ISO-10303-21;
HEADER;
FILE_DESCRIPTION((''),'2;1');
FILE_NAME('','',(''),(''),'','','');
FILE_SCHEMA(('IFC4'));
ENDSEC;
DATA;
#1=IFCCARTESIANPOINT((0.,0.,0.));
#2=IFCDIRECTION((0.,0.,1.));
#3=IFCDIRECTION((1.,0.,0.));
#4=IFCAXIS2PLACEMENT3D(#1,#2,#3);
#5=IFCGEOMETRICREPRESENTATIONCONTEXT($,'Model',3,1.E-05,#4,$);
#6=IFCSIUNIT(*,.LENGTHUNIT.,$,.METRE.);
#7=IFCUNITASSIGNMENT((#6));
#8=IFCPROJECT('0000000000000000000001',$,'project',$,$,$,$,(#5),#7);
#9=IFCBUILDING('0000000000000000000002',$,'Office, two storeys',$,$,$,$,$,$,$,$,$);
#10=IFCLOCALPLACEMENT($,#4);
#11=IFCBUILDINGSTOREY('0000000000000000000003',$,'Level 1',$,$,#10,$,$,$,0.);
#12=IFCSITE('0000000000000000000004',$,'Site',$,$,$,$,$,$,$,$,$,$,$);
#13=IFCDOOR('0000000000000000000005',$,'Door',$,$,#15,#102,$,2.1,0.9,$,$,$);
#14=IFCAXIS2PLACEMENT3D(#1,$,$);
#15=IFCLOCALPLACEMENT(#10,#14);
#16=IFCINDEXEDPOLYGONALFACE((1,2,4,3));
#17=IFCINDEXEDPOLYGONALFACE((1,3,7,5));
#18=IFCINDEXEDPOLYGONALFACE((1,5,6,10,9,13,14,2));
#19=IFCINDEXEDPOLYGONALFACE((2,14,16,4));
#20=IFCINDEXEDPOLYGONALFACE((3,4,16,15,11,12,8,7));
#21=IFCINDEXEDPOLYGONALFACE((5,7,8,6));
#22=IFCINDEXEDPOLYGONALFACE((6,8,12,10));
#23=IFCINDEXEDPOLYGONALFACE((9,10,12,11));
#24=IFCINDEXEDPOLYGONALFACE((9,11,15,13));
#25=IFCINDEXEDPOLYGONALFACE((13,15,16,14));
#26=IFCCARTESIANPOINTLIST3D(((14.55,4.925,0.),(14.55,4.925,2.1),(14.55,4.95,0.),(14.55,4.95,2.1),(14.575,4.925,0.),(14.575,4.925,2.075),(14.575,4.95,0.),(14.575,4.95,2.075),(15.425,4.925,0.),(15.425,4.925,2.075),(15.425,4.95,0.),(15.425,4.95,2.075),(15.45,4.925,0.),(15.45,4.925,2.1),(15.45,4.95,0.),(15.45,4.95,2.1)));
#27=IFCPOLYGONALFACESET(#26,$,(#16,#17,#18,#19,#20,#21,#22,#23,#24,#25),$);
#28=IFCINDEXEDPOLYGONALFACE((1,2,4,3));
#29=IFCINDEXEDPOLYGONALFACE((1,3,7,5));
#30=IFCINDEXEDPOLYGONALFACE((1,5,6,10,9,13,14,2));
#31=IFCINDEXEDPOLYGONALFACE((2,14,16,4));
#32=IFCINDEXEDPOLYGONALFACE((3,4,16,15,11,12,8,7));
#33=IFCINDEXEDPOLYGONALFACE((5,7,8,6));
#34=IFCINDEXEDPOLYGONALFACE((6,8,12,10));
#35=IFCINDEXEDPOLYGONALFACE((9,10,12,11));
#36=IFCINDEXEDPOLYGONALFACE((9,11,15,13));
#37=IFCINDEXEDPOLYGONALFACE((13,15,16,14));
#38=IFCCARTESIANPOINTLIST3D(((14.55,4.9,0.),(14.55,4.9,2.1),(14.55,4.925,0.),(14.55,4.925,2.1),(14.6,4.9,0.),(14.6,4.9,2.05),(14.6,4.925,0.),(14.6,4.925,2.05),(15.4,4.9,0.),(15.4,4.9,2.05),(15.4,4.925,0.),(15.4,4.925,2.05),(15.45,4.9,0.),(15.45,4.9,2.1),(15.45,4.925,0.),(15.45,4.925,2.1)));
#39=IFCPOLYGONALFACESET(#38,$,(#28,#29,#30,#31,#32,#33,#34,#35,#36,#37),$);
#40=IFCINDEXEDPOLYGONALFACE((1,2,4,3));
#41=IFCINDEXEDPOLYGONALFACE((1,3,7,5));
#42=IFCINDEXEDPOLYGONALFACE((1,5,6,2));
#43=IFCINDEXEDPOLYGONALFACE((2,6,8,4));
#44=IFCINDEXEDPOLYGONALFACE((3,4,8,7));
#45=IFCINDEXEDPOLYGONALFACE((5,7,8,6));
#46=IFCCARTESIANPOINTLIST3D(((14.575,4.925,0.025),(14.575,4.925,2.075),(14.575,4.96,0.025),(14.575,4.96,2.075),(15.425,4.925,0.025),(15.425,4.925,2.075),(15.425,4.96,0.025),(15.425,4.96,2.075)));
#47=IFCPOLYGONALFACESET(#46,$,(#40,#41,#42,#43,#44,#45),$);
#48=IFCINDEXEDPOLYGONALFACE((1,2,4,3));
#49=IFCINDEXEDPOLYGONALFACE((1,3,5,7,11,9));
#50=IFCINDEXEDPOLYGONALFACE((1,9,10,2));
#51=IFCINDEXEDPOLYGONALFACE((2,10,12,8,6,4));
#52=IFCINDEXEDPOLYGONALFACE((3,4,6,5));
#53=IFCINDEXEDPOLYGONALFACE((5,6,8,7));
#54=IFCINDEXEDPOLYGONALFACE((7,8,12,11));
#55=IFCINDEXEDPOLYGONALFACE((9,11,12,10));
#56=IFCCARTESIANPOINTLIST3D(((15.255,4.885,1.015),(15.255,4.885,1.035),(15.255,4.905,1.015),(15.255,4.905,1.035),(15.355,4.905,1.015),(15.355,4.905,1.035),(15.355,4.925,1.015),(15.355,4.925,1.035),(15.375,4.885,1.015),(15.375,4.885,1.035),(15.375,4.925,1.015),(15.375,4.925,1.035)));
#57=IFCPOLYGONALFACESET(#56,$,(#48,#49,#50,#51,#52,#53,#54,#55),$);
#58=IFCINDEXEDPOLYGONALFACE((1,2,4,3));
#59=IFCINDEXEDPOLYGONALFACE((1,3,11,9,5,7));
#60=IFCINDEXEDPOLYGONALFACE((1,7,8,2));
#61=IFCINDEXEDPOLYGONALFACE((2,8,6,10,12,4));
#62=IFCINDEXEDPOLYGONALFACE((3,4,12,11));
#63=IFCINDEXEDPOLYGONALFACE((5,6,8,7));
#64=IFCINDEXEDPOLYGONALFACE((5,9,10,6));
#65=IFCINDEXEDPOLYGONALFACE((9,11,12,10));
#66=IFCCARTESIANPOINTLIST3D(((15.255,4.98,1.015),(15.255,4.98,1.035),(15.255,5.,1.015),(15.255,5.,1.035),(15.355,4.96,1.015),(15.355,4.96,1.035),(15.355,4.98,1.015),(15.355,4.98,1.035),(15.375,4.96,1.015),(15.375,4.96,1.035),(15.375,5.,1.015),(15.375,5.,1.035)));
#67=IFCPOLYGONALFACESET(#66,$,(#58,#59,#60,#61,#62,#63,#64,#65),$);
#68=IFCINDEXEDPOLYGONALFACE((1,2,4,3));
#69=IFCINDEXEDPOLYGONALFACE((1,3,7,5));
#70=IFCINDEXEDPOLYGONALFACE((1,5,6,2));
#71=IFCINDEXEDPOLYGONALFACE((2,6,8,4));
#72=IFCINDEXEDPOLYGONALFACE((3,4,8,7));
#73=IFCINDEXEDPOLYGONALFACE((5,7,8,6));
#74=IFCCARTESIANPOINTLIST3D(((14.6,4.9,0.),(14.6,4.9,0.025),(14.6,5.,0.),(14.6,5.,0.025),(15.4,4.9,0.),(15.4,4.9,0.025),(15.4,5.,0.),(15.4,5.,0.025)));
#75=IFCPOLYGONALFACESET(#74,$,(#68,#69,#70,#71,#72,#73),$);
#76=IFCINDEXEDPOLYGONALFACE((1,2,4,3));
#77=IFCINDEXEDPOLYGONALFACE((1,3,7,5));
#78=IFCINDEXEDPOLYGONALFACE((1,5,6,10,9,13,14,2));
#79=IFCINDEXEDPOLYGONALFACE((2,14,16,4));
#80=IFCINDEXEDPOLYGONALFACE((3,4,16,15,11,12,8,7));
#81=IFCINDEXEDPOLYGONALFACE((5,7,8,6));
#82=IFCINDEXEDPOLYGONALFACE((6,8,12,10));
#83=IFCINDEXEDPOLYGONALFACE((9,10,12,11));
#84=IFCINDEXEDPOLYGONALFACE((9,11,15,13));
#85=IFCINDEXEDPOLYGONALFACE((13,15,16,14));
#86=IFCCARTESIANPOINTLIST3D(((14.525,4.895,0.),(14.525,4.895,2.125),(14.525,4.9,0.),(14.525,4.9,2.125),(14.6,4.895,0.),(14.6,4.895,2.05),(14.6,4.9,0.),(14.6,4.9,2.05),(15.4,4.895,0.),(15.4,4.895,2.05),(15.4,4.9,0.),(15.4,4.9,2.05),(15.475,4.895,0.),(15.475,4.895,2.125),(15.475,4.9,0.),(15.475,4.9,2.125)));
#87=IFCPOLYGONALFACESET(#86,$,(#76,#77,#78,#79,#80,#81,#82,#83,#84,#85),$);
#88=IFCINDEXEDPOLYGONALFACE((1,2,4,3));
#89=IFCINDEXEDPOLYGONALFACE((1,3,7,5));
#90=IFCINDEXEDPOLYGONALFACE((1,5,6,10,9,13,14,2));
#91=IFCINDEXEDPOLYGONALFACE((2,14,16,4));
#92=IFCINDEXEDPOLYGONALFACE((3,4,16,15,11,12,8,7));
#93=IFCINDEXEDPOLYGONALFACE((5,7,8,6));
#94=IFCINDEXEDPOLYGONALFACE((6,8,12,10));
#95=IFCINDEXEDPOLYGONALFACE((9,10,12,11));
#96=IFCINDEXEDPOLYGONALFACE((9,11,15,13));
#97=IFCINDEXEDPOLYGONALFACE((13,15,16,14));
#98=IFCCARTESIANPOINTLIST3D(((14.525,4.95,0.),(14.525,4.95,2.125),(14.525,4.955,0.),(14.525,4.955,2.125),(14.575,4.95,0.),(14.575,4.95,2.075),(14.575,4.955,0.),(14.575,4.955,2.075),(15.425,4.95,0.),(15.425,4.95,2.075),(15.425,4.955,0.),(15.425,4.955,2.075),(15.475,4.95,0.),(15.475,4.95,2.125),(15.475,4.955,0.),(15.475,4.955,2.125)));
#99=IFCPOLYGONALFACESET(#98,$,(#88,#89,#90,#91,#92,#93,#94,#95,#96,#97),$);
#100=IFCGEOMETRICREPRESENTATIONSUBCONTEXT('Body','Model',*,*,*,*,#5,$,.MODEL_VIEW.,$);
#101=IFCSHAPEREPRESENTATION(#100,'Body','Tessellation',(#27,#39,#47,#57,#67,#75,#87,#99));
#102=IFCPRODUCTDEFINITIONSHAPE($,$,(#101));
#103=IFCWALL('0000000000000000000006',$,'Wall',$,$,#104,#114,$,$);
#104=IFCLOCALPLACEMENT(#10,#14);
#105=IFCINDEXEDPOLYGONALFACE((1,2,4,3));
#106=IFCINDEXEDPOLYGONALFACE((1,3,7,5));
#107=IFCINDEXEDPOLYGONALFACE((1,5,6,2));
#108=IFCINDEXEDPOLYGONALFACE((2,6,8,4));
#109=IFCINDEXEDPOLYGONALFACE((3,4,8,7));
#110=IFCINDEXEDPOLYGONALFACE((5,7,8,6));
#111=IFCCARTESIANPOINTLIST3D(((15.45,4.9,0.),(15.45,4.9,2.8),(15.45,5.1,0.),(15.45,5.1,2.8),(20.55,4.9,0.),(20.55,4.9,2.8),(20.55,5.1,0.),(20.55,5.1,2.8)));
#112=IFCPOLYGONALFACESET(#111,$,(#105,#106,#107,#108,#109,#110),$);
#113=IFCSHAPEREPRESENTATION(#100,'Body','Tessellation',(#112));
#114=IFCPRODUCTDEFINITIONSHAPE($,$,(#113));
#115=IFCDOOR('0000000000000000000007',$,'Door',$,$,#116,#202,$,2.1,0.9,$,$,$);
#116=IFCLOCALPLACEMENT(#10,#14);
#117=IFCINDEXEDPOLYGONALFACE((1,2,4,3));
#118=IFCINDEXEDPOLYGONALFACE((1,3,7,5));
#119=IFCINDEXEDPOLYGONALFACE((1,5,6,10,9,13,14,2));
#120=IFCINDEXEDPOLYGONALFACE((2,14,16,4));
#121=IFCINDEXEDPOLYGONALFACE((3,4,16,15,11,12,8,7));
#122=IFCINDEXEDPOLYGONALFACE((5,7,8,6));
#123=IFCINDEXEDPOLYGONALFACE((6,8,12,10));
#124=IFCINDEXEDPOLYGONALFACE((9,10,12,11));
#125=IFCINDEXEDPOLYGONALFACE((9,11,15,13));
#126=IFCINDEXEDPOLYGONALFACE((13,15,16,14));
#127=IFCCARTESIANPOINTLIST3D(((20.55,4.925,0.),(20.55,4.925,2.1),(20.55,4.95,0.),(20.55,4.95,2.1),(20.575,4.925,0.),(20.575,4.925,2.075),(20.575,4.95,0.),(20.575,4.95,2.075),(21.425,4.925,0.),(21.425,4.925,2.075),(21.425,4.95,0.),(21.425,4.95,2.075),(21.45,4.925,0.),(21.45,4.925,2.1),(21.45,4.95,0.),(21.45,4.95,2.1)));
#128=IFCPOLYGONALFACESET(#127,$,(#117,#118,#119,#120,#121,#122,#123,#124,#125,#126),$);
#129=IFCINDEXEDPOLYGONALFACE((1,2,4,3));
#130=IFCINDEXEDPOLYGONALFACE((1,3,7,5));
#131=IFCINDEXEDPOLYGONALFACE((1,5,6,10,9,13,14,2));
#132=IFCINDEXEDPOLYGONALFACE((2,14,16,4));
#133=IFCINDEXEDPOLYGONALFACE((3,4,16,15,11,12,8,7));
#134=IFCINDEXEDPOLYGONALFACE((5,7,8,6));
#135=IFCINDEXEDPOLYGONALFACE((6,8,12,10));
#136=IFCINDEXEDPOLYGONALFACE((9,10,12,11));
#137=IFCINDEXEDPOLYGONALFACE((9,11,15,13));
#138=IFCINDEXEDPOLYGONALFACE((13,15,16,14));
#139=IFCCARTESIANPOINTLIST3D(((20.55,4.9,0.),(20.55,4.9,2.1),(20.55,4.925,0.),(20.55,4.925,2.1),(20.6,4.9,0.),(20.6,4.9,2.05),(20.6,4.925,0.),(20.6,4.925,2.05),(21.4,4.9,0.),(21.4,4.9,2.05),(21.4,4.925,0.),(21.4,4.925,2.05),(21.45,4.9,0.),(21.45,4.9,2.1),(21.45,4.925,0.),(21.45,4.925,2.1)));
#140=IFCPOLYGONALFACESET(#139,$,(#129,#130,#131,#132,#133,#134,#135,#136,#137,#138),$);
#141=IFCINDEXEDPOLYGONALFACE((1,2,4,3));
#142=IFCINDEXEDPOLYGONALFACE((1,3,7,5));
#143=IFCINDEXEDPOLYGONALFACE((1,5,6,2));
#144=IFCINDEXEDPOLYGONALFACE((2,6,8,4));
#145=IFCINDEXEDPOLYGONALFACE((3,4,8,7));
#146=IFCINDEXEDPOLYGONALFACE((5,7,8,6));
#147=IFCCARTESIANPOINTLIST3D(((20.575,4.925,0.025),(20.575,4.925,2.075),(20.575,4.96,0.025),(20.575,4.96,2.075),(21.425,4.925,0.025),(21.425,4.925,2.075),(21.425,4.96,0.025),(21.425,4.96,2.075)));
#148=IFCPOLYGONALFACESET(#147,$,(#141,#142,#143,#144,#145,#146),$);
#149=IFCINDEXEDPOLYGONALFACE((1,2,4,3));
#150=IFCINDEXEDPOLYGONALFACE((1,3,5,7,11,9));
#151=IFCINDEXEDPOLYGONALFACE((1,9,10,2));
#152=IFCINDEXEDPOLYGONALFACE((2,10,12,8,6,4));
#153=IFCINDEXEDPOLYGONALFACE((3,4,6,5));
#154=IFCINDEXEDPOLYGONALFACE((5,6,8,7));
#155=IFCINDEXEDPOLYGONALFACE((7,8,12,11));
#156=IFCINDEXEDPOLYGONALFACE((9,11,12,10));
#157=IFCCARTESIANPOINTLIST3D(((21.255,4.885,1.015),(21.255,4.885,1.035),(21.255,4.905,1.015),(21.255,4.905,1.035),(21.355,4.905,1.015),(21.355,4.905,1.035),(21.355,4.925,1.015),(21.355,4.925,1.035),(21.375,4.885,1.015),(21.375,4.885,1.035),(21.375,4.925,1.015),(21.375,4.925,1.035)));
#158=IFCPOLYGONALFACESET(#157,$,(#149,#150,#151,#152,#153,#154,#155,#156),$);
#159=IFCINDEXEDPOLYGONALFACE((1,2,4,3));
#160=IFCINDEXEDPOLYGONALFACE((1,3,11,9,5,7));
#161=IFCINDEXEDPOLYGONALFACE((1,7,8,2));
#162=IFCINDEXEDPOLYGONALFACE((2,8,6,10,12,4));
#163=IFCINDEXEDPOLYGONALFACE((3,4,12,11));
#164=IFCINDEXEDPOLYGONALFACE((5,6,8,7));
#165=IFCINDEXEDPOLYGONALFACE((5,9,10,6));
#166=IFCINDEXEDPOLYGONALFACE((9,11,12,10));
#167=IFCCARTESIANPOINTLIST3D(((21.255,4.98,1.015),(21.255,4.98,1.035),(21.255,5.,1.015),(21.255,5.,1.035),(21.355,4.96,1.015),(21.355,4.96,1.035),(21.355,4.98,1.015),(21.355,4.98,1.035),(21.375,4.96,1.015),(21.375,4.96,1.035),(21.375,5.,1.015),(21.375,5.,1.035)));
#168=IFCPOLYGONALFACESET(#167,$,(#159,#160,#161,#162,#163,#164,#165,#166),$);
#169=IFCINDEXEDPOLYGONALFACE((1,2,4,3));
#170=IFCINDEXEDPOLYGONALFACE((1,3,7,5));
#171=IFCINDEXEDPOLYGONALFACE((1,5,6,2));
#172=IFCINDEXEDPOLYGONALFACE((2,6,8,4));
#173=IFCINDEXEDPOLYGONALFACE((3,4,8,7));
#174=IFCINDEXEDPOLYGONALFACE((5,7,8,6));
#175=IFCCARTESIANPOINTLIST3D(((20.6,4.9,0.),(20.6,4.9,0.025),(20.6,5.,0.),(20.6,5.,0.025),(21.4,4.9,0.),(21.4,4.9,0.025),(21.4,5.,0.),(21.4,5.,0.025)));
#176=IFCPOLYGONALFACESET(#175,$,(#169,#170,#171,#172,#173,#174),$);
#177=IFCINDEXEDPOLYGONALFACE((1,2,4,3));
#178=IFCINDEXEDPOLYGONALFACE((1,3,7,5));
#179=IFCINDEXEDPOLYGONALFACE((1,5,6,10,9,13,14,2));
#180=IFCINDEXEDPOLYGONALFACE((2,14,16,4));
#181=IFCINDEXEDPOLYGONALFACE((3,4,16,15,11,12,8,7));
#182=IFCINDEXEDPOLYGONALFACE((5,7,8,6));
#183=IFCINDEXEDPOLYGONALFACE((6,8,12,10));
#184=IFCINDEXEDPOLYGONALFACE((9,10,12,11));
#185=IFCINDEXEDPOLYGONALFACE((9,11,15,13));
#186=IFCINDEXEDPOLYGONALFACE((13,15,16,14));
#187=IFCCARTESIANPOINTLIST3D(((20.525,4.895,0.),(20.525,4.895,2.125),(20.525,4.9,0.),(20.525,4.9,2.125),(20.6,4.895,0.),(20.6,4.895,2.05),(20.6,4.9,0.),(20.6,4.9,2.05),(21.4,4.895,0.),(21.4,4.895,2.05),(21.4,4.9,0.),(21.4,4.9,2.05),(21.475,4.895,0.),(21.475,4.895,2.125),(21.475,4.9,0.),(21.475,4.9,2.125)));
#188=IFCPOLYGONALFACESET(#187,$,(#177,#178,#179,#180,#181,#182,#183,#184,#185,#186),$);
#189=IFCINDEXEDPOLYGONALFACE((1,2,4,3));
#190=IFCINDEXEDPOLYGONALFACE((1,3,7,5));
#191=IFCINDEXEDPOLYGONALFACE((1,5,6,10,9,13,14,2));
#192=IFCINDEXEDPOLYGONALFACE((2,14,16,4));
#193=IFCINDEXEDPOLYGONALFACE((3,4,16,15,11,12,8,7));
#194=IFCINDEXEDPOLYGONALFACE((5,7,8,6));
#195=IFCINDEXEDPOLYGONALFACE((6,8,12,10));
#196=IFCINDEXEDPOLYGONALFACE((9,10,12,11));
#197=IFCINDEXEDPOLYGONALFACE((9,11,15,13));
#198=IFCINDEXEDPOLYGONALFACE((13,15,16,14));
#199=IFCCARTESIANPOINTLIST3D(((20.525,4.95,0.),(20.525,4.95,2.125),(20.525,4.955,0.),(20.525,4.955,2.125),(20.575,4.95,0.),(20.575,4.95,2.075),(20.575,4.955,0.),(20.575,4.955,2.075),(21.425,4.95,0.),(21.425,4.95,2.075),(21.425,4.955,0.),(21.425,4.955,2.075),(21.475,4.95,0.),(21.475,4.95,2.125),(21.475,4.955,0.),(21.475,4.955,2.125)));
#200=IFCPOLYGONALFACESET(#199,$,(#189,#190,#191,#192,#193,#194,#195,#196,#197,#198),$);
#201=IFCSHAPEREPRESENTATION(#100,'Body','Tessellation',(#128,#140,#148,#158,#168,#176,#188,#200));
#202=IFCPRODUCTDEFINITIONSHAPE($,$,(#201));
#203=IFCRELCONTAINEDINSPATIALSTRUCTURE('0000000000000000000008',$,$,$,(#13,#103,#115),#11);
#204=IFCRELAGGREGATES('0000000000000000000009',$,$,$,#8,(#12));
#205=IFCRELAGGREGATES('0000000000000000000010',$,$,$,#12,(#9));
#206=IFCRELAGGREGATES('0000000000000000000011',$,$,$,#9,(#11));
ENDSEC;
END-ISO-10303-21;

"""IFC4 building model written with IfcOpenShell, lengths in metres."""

from ifc_helpers import new_model, si_unit, frame, origin_with_axes, place, context, subcontext, project, spatial, line, indexed_curve, outline, extrude, element, save


model = new_model("IFC4")

# Units and contexts
model_context = context("Model", 3, precision=1e-05, world=origin_with_axes())
body_context = subcontext(model_context, "Body", "Model", "MODEL_VIEW")
ifc_project = project(units=[si_unit("LENGTHUNIT", "METRE")], contexts=[model_context])

# Site, building, storey
site = spatial("IfcSite", under=ifc_project, Name="Site")
building = spatial("IfcBuilding", under=site, Name="Office, two storeys")
storey_placement = place(None, origin_with_axes())
storey = spatial("IfcBuildingStorey", under=building, at=storey_placement, Name="Level 1", Elevation=0.0)

# Door
door_1_placement = place(storey_placement, frame((14.55, 4.9, 0.0), z_axis=(0.0, 0.0, 1.0), x_axis=(1.0, 0.0, 0.0)))
element("IfcDoor", 1, at=door_1_placement, inside=storey, Name="Door", OverallHeight=2.1, OverallWidth=0.9, context=body_context, shape_type="SweptSolid", body=[
    extrude(outline(indexed_curve([(0.0, 0.0), (0.0, 2.1), (0.9, 2.1), (0.9, 0.0), (0.875, 0.0), (0.875, 2.075), (0.025, 2.075), (0.025, 0.0)], segments=[line(1, 2, 3, 4, 5, 6, 7, 8, 1)])), frame((0.0, 0.025, 0.0), z_axis=(0.0, -1.0, 0.0), x_axis=(1.0, 0.0, 0.0)), (0.0, 0.0, -1.0), 0.025),
    extrude(outline(indexed_curve([(0.0, 0.0), (0.0, 2.1), (0.9, 2.1), (0.9, 0.0), (0.85, 0.0), (0.85, 2.05), (0.05, 2.05), (0.05, 0.0)], segments=[line(1, 2, 3, 4, 5, 6, 7, 8, 1)])), frame((0.0, 0.0, 0.0), z_axis=(0.0, -1.0, 0.0), x_axis=(1.0, 0.0, 0.0)), (0.0, 0.0, -1.0), 0.025),
    extrude(outline(indexed_curve([(0.0, 0.0), (0.85, 0.0), (0.85, 0.035), (0.0, 0.035)], segments=[line(1, 2, 3, 4, 1)])), frame((0.025, 0.025, 0.025), z_axis=(0.0, 0.0, 1.0), x_axis=(1.0, 0.0, 0.0)), (0.0, 0.0, 1.0), 2.05),
    extrude(outline(indexed_curve([(0.0, 0.0), (0.0, -0.04), (-0.12, -0.04), (-0.12, -0.02), (-0.02, -0.02), (-0.02, 0.0)], segments=[line(1, 2, 3, 4, 5, 6, 1)])), frame((0.825, 0.025, 1.015), z_axis=(0.0, 0.0, 1.0), x_axis=(1.0, 0.0, 0.0)), (0.0, 0.0, 1.0), 0.02),
    extrude(outline(indexed_curve([(0.0, 0.0), (0.0, 0.04), (-0.12, 0.04), (-0.12, 0.02), (-0.02, 0.02), (-0.02, 0.0)], segments=[line(1, 2, 3, 4, 5, 6, 1)])), frame((0.825, 0.06, 1.015), z_axis=(0.0, 0.0, 1.0), x_axis=(1.0, 0.0, 0.0)), (0.0, 0.0, 1.0), 0.02),
    extrude(outline(indexed_curve([(0.0, 0.0), (0.8, 0.0), (0.8, 0.1), (0.0, 0.1)], segments=[line(1, 2, 3, 4, 1)])), frame((0.05, 0.0, 0.0), z_axis=(0.0, 0.0, 1.0), x_axis=(1.0, 0.0, 0.0)), (0.0, 0.0, 1.0), 0.025),
    extrude(outline(indexed_curve([(0.0, 0.0), (0.0, 2.125), (0.95, 2.125), (0.95, 0.0), (0.875, 0.0), (0.875, 2.05), (0.075, 2.05), (0.075, 0.0)], segments=[line(1, 2, 3, 4, 5, 6, 7, 8, 1)])), frame((-0.025, -0.005, 0.0), z_axis=(0.0, -1.0, 0.0), x_axis=(1.0, 0.0, 0.0)), (0.0, 0.0, -1.0), 0.005),
    extrude(outline(indexed_curve([(0.0, 0.0), (0.0, 2.125), (0.95, 2.125), (0.95, 0.0), (0.9, 0.0), (0.9, 2.075), (0.05, 2.075), (0.05, 0.0)], segments=[line(1, 2, 3, 4, 5, 6, 7, 8, 1)])), frame((-0.025, 0.05, 0.0), z_axis=(0.0, -1.0, 0.0), x_axis=(1.0, 0.0, 0.0)), (0.0, 0.0, -1.0), 0.005),
])

# Wall
wall_1_placement = place(storey_placement, frame((15.45, 5.0, 0.0), z_axis=(0.0, 0.0, 1.0), x_axis=(1.0, 0.0, 0.0)))
element("IfcWall", 2, at=wall_1_placement, inside=storey, Name="Wall", context=body_context, shape_type="SweptSolid", body=[
    extrude(outline(indexed_curve([(0.0, 0.0), (0.0, 0.2), (5.1, 0.2), (5.1, 0.0), (0.0, 0.0)], self_intersect=False)), frame((0.0, -0.1, 0.0), z_axis=(0.0, 0.0, 1.0), x_axis=(1.0, 0.0, 0.0)), (0.0, 0.0, 1.0), 2.8),
])

# Door
door_2_placement = place(storey_placement, frame((20.55, 4.9, 0.0), z_axis=(0.0, 0.0, 1.0), x_axis=(1.0, 0.0, 0.0)))
element("IfcDoor", 3, at=door_2_placement, inside=storey, Name="Door", OverallHeight=2.1, OverallWidth=0.9, context=body_context, shape_type="SweptSolid", body=[
    extrude(outline(indexed_curve([(0.0, 0.0), (0.0, 2.1), (0.9, 2.1), (0.9, 0.0), (0.875, 0.0), (0.875, 2.075), (0.025, 2.075), (0.025, 0.0)], segments=[line(1, 2, 3, 4, 5, 6, 7, 8, 1)])), frame((0.0, 0.025, 0.0), z_axis=(0.0, -1.0, 0.0), x_axis=(1.0, 0.0, 0.0)), (0.0, 0.0, -1.0), 0.025),
    extrude(outline(indexed_curve([(0.0, 0.0), (0.0, 2.1), (0.9, 2.1), (0.9, 0.0), (0.85, 0.0), (0.85, 2.05), (0.05, 2.05), (0.05, 0.0)], segments=[line(1, 2, 3, 4, 5, 6, 7, 8, 1)])), frame((0.0, 0.0, 0.0), z_axis=(0.0, -1.0, 0.0), x_axis=(1.0, 0.0, 0.0)), (0.0, 0.0, -1.0), 0.025),
    extrude(outline(indexed_curve([(0.0, 0.0), (0.85, 0.0), (0.85, 0.035), (0.0, 0.035)], segments=[line(1, 2, 3, 4, 1)])), frame((0.025, 0.025, 0.025), z_axis=(0.0, 0.0, 1.0), x_axis=(1.0, 0.0, 0.0)), (0.0, 0.0, 1.0), 2.05),
    extrude(outline(indexed_curve([(0.0, 0.0), (0.0, -0.04), (-0.12, -0.04), (-0.12, -0.02), (-0.02, -0.02), (-0.02, 0.0)], segments=[line(1, 2, 3, 4, 5, 6, 1)])), frame((0.825, 0.025, 1.015), z_axis=(0.0, 0.0, 1.0), x_axis=(1.0, 0.0, 0.0)), (0.0, 0.0, 1.0), 0.02),
    extrude(outline(indexed_curve([(0.0, 0.0), (0.0, 0.04), (-0.12, 0.04), (-0.12, 0.02), (-0.02, 0.02), (-0.02, 0.0)], segments=[line(1, 2, 3, 4, 5, 6, 1)])), frame((0.825, 0.06, 1.015), z_axis=(0.0, 0.0, 1.0), x_axis=(1.0, 0.0, 0.0)), (0.0, 0.0, 1.0), 0.02),
    extrude(outline(indexed_curve([(0.0, 0.0), (0.8, 0.0), (0.8, 0.1), (0.0, 0.1)], segments=[line(1, 2, 3, 4, 1)])), frame((0.05, 0.0, 0.0), z_axis=(0.0, 0.0, 1.0), x_axis=(1.0, 0.0, 0.0)), (0.0, 0.0, 1.0), 0.025),
    extrude(outline(indexed_curve([(0.0, 0.0), (0.0, 2.125), (0.95, 2.125), (0.95, 0.0), (0.875, 0.0), (0.875, 2.05), (0.075, 2.05), (0.075, 0.0)], segments=[line(1, 2, 3, 4, 5, 6, 7, 8, 1)])), frame((-0.025, -0.005, 0.0), z_axis=(0.0, -1.0, 0.0), x_axis=(1.0, 0.0, 0.0)), (0.0, 0.0, -1.0), 0.005),
    extrude(outline(indexed_curve([(0.0, 0.0), (0.0, 2.125), (0.95, 2.125), (0.95, 0.0), (0.9, 0.0), (0.9, 2.075), (0.05, 2.075), (0.05, 0.0)], segments=[line(1, 2, 3, 4, 5, 6, 7, 8, 1)])), frame((-0.025, 0.05, 0.0), z_axis=(0.0, -1.0, 0.0), x_axis=(1.0, 0.0, 0.0)), (0.0, 0.0, -1.0), 0.005),
])

save(model, "model.ifc")
